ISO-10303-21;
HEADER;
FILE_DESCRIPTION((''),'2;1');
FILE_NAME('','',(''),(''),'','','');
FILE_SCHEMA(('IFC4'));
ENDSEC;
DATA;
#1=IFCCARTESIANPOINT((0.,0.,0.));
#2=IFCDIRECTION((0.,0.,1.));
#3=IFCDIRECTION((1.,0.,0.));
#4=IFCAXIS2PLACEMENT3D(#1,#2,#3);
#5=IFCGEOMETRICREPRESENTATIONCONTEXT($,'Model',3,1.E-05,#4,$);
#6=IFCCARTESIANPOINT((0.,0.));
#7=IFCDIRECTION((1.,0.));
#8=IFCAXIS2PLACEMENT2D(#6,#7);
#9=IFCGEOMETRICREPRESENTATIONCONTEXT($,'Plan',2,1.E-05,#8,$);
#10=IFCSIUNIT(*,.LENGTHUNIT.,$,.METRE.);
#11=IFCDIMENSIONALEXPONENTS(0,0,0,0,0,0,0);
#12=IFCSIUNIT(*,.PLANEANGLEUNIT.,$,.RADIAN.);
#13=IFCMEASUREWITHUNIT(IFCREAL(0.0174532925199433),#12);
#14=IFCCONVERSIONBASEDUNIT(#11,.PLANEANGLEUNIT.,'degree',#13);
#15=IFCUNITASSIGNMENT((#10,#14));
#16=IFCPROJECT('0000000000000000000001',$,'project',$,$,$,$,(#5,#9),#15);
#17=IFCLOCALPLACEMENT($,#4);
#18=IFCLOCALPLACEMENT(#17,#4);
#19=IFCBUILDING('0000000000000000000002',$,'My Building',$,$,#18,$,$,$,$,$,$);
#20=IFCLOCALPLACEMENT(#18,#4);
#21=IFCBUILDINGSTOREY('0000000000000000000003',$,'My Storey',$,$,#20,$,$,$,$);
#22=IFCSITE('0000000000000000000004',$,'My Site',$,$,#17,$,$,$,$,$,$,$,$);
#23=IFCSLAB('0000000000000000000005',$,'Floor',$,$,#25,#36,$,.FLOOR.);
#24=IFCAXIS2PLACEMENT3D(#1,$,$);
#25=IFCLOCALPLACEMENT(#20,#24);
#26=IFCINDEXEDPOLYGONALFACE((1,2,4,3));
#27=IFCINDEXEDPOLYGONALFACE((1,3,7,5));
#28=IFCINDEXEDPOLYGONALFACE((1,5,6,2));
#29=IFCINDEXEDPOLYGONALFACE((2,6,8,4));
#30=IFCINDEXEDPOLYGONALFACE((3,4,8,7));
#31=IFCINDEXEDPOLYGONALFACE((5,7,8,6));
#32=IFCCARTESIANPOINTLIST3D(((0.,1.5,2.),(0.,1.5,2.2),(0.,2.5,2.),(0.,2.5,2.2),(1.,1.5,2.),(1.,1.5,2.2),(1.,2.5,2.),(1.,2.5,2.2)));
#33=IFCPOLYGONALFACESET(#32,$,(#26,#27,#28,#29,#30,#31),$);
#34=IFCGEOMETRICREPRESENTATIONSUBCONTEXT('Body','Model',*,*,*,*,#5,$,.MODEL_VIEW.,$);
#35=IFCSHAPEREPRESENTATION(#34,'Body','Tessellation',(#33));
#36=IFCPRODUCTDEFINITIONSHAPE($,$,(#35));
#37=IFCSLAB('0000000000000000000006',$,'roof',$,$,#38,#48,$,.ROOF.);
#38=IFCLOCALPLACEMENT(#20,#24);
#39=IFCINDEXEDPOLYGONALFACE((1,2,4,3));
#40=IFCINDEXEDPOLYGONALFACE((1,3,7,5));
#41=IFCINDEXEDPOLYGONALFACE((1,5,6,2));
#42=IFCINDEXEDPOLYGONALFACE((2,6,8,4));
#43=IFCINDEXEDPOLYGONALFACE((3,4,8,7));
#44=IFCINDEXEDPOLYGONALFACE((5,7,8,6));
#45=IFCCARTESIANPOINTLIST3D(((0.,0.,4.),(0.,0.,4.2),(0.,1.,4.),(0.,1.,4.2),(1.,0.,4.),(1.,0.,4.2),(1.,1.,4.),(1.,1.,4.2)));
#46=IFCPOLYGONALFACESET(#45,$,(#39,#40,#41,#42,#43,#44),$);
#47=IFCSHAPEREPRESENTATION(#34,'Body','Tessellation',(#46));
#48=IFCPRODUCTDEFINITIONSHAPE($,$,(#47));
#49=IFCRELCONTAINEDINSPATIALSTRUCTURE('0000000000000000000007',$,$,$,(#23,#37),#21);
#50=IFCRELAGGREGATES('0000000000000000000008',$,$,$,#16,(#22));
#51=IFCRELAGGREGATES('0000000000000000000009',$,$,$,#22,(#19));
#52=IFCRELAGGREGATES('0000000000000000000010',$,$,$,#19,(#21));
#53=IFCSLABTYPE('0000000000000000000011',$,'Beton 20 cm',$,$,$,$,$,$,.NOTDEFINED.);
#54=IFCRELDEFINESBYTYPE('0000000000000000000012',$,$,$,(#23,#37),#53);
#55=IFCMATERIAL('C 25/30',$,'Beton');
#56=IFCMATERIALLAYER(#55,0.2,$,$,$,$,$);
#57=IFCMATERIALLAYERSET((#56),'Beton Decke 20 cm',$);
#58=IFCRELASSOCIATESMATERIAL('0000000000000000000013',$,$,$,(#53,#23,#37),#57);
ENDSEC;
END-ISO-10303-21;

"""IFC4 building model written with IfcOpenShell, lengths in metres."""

from ifc_helpers import new_model, entity, si_unit, converted_unit, frame, origin_with_axes, origin_2d_with_axis, place, context, subcontext, project, spatial, indexed_curve, outline, extrude, material, layer, layer_set, layer_usage, type_object, element, save


model = new_model("IFC4")

# Units and contexts
model_context = context("Model", 3, precision=1e-05, world=origin_with_axes())
plan_context = context("Plan", 2, precision=1e-05, world=origin_2d_with_axis())
body_context = subcontext(model_context, "Body", "Model", "MODEL_VIEW")
ifc_project = project(units=[si_unit("LENGTHUNIT", "METRE"), converted_unit("PLANEANGLEUNIT", "degree", entity("IfcReal", 0.0174532925199433), si_unit("PLANEANGLEUNIT", "RADIAN"), dimensions=[0, 0, 0, 0, 0, 0, 0])], contexts=[model_context, plan_context])

# Site, building, storey
site_placement = place(None, origin_with_axes())
site = spatial("IfcSite", under=ifc_project, at=site_placement, Name="My Site")
building_placement = place(site_placement, origin_with_axes())
building = spatial("IfcBuilding", under=site, at=building_placement, Name="My Building")
storey_placement = place(building_placement, origin_with_axes())
storey = spatial("IfcBuildingStorey", under=building, at=storey_placement, Name="My Storey")

# Slabs
ifc_material = material(Name="C 25/30", Category="Beton")
ifc_layer = layer(ifc_material, 0.2)
ifc_layer_set = layer_set([ifc_layer], Name="Beton Decke 20 cm")
slab_type = type_object("IfcSlabType", Name="Beton 20 cm", PredefinedType="NOTDEFINED", material=ifc_layer_set)
ifc_layer_usage_1 = layer_usage(ifc_layer_set, "AXIS3", "POSITIVE", 0.0)
slab_1_placement = place(storey_placement, frame((0.0, 1.5, 2.0), z_axis=(0.0, 0.0, 1.0), x_axis=(1.0, 0.0, 0.0)))
element("IfcSlab", 1, at=slab_1_placement, inside=storey, type_object=slab_type, material=ifc_layer_usage_1, Name="Floor", PredefinedType="FLOOR", context=body_context, shape_type="SweptSolid", body=[
    extrude(outline(indexed_curve([(0.0, 0.0), (1.0, 0.0), (1.0, 1.0), (0.0, 1.0), (0.0, 0.0)])), None, (0.0, 0.0, 1.0), 0.2),
])
ifc_layer_usage_2 = layer_usage(ifc_layer_set, "AXIS3", "POSITIVE", 0.0)
slab_2_placement = place(storey_placement, frame((0.0, 0.0, 4.0), z_axis=(0.0, 0.0, 1.0), x_axis=(1.0, 0.0, 0.0)))
element("IfcSlab", 2, at=slab_2_placement, inside=storey, type_object=slab_type, material=ifc_layer_usage_2, Name="roof", PredefinedType="ROOF", context=body_context, shape_type="SweptSolid", body=[
    extrude(outline(indexed_curve([(0.0, 0.0), (1.0, 0.0), (1.0, 1.0), (0.0, 1.0), (0.0, 0.0)])), None, (0.0, 0.0, 1.0), 0.2),
])

save(model, "model.ifc")
